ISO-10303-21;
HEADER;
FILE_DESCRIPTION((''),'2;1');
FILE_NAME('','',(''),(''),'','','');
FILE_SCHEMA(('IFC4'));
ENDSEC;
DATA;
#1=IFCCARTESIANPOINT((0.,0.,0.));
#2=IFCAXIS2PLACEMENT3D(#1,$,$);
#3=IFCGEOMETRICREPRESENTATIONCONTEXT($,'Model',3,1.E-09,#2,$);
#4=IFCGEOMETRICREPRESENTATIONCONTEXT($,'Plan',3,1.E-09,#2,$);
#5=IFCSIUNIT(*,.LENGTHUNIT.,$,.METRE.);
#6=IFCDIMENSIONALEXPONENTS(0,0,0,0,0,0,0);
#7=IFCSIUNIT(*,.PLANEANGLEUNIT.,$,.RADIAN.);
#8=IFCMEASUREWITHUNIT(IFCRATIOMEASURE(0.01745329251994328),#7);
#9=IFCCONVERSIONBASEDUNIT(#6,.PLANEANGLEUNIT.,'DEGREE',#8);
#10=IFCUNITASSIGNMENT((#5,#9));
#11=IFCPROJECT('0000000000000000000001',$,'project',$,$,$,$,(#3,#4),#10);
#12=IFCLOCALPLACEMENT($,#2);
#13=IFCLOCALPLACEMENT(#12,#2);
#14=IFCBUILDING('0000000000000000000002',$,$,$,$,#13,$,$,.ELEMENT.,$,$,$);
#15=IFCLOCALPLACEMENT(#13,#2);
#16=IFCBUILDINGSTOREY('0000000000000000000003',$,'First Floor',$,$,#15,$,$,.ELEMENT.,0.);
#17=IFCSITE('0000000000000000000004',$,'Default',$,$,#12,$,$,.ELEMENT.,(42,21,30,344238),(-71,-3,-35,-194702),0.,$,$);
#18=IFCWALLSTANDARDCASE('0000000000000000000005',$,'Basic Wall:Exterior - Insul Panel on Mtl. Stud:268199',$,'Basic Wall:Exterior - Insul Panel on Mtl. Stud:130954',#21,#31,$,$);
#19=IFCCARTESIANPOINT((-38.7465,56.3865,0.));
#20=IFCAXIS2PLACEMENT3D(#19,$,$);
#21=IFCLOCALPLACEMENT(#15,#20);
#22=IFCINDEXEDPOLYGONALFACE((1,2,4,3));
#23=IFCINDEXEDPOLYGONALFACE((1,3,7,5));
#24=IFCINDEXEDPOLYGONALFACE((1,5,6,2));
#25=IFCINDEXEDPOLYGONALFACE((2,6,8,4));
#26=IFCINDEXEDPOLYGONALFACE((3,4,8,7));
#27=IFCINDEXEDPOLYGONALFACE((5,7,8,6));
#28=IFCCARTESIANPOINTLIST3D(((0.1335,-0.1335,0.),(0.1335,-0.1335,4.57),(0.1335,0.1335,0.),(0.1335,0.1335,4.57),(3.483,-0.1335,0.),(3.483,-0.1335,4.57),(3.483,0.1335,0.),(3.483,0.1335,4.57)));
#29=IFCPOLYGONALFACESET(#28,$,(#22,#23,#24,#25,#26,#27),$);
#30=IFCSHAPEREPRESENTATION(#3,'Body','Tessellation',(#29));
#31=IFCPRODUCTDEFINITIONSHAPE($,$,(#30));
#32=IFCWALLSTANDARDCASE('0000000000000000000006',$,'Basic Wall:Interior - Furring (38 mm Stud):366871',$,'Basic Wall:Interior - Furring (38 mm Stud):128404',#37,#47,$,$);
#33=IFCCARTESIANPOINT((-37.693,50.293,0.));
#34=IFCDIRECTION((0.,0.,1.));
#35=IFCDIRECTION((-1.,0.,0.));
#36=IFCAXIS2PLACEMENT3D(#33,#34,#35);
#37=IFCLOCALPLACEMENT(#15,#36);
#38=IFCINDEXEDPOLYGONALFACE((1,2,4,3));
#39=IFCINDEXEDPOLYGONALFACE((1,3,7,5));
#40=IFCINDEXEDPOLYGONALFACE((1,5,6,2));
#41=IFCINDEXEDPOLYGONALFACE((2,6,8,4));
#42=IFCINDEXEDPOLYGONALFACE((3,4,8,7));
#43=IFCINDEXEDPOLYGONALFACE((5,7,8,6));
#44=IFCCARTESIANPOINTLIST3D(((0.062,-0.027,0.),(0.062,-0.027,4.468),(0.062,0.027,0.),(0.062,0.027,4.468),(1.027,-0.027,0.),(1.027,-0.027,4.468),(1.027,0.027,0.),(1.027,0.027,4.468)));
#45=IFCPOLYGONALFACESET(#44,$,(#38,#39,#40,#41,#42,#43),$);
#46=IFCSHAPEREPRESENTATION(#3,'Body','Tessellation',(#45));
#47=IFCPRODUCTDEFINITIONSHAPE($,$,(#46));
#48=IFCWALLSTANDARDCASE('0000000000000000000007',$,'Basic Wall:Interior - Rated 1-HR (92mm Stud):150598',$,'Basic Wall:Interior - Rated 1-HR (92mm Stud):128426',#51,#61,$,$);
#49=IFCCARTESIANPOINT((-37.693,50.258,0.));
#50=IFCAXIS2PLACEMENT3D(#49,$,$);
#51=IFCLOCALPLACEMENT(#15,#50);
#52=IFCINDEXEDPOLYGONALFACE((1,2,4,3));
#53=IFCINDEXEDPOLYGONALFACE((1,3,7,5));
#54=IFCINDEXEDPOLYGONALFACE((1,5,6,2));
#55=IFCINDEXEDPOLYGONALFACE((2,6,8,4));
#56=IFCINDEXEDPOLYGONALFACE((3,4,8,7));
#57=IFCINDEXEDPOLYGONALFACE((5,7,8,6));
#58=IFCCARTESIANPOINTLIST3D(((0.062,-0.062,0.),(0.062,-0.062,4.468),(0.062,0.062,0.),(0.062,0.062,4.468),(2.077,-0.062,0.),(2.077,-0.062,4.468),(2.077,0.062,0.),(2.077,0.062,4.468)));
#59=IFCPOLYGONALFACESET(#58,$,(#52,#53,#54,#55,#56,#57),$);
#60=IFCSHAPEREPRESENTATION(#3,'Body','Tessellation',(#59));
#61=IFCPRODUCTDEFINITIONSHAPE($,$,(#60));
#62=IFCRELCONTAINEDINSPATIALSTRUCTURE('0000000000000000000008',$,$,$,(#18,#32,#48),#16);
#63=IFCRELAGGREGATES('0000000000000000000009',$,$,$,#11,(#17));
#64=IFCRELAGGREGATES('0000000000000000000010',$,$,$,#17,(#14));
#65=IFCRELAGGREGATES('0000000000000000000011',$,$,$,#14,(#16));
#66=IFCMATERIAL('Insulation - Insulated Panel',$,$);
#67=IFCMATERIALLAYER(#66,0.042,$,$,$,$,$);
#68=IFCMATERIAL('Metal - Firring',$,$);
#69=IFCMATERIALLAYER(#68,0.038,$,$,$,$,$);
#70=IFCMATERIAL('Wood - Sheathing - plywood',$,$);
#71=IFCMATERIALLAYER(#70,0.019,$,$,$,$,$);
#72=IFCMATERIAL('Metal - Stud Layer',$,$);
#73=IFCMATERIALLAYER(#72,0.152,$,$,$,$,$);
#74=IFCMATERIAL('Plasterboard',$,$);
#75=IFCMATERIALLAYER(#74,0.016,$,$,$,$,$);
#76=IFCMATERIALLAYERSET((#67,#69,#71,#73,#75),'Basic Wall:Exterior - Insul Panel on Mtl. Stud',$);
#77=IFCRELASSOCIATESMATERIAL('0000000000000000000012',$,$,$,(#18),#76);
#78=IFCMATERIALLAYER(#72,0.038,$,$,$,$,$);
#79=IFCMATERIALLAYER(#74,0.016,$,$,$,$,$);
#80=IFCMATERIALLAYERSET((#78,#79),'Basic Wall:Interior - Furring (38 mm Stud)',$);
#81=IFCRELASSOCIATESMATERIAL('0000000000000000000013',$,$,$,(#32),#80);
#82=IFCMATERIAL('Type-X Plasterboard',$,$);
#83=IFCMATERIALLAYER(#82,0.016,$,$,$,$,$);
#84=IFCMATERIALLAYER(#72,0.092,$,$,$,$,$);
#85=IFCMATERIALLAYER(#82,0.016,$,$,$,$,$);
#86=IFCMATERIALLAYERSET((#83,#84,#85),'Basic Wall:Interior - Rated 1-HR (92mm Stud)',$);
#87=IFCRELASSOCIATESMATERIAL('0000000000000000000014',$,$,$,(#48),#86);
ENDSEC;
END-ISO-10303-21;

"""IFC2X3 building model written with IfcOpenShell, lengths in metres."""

from ifc_helpers import new_model, entity, si_unit, converted_unit, frame, frame_2d, origin, place, context, project, spatial, rectangle, extrude, material, layer, layer_set, layer_usage, element, save


model = new_model("IFC2X3")

# Units and contexts
model_context = context("Model", 3, precision=1e-09, world=origin())
plan_context = context("Plan", 3, precision=1e-09, world=origin())
ifc_project = project(units=[si_unit("LENGTHUNIT", "METRE"), converted_unit("PLANEANGLEUNIT", "DEGREE", entity("IfcRatioMeasure", 0.01745329251994328), si_unit("PLANEANGLEUNIT", "RADIAN"), dimensions=[0, 0, 0, 0, 0, 0, 0])], contexts=[model_context, plan_context])

# Site, building, storey
site_placement = place(None, origin())
site = spatial("IfcSite", under=ifc_project, at=site_placement, Name="Default", CompositionType="ELEMENT", RefLatitude=(42, 21, 30, 344238), RefLongitude=(-71, -3, -35, -194702), RefElevation=0.0)
building_placement = place(site_placement, origin())
building = spatial("IfcBuilding", under=site, at=building_placement, CompositionType="ELEMENT")
storey_placement = place(building_placement, origin())
storey = spatial("IfcBuildingStorey", under=building, at=storey_placement, Name="First Floor", CompositionType="ELEMENT", Elevation=0.0)

# Wall
ifc_material_1 = material(Name="Insulation - Insulated Panel")
ifc_layer_1 = layer(ifc_material_1, 0.042)
ifc_material_2 = material(Name="Metal - Firring")
ifc_layer_2 = layer(ifc_material_2, 0.038)
ifc_material_3 = material(Name="Wood - Sheathing - plywood")
ifc_layer_3 = layer(ifc_material_3, 0.019)
ifc_material_4 = material(Name="Metal - Stud Layer")
ifc_layer_4 = layer(ifc_material_4, 0.152)
ifc_material_5 = material(Name="Plasterboard")
ifc_layer_5 = layer(ifc_material_5, 0.016)
ifc_layer_set_1 = layer_set([ifc_layer_1, ifc_layer_2, ifc_layer_3, ifc_layer_4, ifc_layer_5], Name="Basic Wall:Exterior - Insul Panel on Mtl. Stud")
ifc_layer_usage_1 = layer_usage(ifc_layer_set_1, "AXIS2", "NEGATIVE", 0.1335)
wall_1_placement = place(storey_placement, frame((-38.7465, 56.3865, 0.0)))
element("IfcWallStandardCase", 1, at=wall_1_placement, inside=storey, material=ifc_layer_usage_1, Name="Basic Wall:Exterior - Insul Panel on Mtl. Stud:268199", ObjectType="Basic Wall:Exterior - Insul Panel on Mtl. Stud:130954", context=model_context, shape_type="SweptSolid", body=[
    extrude(rectangle(XDim=3.3495, YDim=0.267, at=frame_2d((1.8083, 0.0), x_axis=(-1.0, 0.0))), origin(), (0.0, 0.0, 1.0), 4.57),
])
ifc_material_6 = material(Name="Type-X Plasterboard")
ifc_layer_6 = layer(ifc_material_6, 0.016)
ifc_layer_7 = layer(ifc_material_4, 0.092)
ifc_layer_8 = layer(ifc_material_6, 0.016)
ifc_layer_set_2 = layer_set([ifc_layer_6, ifc_layer_7, ifc_layer_8], Name="Basic Wall:Interior - Rated 1-HR (92mm Stud)")
ifc_layer_usage_2 = layer_usage(ifc_layer_set_2, "AXIS2", "NEGATIVE", 0.062)

# Shared definitions
ifc_layer_9 = layer(ifc_material_4, 0.038)
ifc_layer_10 = layer(ifc_material_5, 0.016)
ifc_layer_set_3 = layer_set([ifc_layer_9, ifc_layer_10], Name="Basic Wall:Interior - Furring (38 mm Stud)")
ifc_layer_usage_3 = layer_usage(ifc_layer_set_3, "AXIS2", "NEGATIVE", 0.027)

# Walls
wall_2_placement = place(storey_placement, frame((-37.693, 50.293, 0.0), z_axis=(0.0, 0.0, 1.0), x_axis=(-1.0, 0.0, 0.0)))
element("IfcWallStandardCase", 2, at=wall_2_placement, inside=storey, material=ifc_layer_usage_3, Name="Basic Wall:Interior - Furring (38 mm Stud):366871", ObjectType="Basic Wall:Interior - Furring (38 mm Stud):128404", context=model_context, shape_type="SweptSolid", body=[
    extrude(rectangle(XDim=0.965, YDim=0.054, at=frame_2d((0.5445, 0.0), x_axis=(-1.0, 0.0))), origin(), (0.0, 0.0, 1.0), 4.468),
])
wall_3_placement = place(storey_placement, frame((-37.693, 50.258, 0.0)))
element("IfcWallStandardCase", 3, at=wall_3_placement, inside=storey, material=ifc_layer_usage_2, Name="Basic Wall:Interior - Rated 1-HR (92mm Stud):150598", ObjectType="Basic Wall:Interior - Rated 1-HR (92mm Stud):128426", context=model_context, shape_type="SweptSolid", body=[
    extrude(rectangle(XDim=2.015, YDim=0.124, at=frame_2d((1.0695, 0.0), x_axis=(-1.0, 0.0))), origin(), (0.0, 0.0, 1.0), 4.468),
])

save(model, "model.ifc")
